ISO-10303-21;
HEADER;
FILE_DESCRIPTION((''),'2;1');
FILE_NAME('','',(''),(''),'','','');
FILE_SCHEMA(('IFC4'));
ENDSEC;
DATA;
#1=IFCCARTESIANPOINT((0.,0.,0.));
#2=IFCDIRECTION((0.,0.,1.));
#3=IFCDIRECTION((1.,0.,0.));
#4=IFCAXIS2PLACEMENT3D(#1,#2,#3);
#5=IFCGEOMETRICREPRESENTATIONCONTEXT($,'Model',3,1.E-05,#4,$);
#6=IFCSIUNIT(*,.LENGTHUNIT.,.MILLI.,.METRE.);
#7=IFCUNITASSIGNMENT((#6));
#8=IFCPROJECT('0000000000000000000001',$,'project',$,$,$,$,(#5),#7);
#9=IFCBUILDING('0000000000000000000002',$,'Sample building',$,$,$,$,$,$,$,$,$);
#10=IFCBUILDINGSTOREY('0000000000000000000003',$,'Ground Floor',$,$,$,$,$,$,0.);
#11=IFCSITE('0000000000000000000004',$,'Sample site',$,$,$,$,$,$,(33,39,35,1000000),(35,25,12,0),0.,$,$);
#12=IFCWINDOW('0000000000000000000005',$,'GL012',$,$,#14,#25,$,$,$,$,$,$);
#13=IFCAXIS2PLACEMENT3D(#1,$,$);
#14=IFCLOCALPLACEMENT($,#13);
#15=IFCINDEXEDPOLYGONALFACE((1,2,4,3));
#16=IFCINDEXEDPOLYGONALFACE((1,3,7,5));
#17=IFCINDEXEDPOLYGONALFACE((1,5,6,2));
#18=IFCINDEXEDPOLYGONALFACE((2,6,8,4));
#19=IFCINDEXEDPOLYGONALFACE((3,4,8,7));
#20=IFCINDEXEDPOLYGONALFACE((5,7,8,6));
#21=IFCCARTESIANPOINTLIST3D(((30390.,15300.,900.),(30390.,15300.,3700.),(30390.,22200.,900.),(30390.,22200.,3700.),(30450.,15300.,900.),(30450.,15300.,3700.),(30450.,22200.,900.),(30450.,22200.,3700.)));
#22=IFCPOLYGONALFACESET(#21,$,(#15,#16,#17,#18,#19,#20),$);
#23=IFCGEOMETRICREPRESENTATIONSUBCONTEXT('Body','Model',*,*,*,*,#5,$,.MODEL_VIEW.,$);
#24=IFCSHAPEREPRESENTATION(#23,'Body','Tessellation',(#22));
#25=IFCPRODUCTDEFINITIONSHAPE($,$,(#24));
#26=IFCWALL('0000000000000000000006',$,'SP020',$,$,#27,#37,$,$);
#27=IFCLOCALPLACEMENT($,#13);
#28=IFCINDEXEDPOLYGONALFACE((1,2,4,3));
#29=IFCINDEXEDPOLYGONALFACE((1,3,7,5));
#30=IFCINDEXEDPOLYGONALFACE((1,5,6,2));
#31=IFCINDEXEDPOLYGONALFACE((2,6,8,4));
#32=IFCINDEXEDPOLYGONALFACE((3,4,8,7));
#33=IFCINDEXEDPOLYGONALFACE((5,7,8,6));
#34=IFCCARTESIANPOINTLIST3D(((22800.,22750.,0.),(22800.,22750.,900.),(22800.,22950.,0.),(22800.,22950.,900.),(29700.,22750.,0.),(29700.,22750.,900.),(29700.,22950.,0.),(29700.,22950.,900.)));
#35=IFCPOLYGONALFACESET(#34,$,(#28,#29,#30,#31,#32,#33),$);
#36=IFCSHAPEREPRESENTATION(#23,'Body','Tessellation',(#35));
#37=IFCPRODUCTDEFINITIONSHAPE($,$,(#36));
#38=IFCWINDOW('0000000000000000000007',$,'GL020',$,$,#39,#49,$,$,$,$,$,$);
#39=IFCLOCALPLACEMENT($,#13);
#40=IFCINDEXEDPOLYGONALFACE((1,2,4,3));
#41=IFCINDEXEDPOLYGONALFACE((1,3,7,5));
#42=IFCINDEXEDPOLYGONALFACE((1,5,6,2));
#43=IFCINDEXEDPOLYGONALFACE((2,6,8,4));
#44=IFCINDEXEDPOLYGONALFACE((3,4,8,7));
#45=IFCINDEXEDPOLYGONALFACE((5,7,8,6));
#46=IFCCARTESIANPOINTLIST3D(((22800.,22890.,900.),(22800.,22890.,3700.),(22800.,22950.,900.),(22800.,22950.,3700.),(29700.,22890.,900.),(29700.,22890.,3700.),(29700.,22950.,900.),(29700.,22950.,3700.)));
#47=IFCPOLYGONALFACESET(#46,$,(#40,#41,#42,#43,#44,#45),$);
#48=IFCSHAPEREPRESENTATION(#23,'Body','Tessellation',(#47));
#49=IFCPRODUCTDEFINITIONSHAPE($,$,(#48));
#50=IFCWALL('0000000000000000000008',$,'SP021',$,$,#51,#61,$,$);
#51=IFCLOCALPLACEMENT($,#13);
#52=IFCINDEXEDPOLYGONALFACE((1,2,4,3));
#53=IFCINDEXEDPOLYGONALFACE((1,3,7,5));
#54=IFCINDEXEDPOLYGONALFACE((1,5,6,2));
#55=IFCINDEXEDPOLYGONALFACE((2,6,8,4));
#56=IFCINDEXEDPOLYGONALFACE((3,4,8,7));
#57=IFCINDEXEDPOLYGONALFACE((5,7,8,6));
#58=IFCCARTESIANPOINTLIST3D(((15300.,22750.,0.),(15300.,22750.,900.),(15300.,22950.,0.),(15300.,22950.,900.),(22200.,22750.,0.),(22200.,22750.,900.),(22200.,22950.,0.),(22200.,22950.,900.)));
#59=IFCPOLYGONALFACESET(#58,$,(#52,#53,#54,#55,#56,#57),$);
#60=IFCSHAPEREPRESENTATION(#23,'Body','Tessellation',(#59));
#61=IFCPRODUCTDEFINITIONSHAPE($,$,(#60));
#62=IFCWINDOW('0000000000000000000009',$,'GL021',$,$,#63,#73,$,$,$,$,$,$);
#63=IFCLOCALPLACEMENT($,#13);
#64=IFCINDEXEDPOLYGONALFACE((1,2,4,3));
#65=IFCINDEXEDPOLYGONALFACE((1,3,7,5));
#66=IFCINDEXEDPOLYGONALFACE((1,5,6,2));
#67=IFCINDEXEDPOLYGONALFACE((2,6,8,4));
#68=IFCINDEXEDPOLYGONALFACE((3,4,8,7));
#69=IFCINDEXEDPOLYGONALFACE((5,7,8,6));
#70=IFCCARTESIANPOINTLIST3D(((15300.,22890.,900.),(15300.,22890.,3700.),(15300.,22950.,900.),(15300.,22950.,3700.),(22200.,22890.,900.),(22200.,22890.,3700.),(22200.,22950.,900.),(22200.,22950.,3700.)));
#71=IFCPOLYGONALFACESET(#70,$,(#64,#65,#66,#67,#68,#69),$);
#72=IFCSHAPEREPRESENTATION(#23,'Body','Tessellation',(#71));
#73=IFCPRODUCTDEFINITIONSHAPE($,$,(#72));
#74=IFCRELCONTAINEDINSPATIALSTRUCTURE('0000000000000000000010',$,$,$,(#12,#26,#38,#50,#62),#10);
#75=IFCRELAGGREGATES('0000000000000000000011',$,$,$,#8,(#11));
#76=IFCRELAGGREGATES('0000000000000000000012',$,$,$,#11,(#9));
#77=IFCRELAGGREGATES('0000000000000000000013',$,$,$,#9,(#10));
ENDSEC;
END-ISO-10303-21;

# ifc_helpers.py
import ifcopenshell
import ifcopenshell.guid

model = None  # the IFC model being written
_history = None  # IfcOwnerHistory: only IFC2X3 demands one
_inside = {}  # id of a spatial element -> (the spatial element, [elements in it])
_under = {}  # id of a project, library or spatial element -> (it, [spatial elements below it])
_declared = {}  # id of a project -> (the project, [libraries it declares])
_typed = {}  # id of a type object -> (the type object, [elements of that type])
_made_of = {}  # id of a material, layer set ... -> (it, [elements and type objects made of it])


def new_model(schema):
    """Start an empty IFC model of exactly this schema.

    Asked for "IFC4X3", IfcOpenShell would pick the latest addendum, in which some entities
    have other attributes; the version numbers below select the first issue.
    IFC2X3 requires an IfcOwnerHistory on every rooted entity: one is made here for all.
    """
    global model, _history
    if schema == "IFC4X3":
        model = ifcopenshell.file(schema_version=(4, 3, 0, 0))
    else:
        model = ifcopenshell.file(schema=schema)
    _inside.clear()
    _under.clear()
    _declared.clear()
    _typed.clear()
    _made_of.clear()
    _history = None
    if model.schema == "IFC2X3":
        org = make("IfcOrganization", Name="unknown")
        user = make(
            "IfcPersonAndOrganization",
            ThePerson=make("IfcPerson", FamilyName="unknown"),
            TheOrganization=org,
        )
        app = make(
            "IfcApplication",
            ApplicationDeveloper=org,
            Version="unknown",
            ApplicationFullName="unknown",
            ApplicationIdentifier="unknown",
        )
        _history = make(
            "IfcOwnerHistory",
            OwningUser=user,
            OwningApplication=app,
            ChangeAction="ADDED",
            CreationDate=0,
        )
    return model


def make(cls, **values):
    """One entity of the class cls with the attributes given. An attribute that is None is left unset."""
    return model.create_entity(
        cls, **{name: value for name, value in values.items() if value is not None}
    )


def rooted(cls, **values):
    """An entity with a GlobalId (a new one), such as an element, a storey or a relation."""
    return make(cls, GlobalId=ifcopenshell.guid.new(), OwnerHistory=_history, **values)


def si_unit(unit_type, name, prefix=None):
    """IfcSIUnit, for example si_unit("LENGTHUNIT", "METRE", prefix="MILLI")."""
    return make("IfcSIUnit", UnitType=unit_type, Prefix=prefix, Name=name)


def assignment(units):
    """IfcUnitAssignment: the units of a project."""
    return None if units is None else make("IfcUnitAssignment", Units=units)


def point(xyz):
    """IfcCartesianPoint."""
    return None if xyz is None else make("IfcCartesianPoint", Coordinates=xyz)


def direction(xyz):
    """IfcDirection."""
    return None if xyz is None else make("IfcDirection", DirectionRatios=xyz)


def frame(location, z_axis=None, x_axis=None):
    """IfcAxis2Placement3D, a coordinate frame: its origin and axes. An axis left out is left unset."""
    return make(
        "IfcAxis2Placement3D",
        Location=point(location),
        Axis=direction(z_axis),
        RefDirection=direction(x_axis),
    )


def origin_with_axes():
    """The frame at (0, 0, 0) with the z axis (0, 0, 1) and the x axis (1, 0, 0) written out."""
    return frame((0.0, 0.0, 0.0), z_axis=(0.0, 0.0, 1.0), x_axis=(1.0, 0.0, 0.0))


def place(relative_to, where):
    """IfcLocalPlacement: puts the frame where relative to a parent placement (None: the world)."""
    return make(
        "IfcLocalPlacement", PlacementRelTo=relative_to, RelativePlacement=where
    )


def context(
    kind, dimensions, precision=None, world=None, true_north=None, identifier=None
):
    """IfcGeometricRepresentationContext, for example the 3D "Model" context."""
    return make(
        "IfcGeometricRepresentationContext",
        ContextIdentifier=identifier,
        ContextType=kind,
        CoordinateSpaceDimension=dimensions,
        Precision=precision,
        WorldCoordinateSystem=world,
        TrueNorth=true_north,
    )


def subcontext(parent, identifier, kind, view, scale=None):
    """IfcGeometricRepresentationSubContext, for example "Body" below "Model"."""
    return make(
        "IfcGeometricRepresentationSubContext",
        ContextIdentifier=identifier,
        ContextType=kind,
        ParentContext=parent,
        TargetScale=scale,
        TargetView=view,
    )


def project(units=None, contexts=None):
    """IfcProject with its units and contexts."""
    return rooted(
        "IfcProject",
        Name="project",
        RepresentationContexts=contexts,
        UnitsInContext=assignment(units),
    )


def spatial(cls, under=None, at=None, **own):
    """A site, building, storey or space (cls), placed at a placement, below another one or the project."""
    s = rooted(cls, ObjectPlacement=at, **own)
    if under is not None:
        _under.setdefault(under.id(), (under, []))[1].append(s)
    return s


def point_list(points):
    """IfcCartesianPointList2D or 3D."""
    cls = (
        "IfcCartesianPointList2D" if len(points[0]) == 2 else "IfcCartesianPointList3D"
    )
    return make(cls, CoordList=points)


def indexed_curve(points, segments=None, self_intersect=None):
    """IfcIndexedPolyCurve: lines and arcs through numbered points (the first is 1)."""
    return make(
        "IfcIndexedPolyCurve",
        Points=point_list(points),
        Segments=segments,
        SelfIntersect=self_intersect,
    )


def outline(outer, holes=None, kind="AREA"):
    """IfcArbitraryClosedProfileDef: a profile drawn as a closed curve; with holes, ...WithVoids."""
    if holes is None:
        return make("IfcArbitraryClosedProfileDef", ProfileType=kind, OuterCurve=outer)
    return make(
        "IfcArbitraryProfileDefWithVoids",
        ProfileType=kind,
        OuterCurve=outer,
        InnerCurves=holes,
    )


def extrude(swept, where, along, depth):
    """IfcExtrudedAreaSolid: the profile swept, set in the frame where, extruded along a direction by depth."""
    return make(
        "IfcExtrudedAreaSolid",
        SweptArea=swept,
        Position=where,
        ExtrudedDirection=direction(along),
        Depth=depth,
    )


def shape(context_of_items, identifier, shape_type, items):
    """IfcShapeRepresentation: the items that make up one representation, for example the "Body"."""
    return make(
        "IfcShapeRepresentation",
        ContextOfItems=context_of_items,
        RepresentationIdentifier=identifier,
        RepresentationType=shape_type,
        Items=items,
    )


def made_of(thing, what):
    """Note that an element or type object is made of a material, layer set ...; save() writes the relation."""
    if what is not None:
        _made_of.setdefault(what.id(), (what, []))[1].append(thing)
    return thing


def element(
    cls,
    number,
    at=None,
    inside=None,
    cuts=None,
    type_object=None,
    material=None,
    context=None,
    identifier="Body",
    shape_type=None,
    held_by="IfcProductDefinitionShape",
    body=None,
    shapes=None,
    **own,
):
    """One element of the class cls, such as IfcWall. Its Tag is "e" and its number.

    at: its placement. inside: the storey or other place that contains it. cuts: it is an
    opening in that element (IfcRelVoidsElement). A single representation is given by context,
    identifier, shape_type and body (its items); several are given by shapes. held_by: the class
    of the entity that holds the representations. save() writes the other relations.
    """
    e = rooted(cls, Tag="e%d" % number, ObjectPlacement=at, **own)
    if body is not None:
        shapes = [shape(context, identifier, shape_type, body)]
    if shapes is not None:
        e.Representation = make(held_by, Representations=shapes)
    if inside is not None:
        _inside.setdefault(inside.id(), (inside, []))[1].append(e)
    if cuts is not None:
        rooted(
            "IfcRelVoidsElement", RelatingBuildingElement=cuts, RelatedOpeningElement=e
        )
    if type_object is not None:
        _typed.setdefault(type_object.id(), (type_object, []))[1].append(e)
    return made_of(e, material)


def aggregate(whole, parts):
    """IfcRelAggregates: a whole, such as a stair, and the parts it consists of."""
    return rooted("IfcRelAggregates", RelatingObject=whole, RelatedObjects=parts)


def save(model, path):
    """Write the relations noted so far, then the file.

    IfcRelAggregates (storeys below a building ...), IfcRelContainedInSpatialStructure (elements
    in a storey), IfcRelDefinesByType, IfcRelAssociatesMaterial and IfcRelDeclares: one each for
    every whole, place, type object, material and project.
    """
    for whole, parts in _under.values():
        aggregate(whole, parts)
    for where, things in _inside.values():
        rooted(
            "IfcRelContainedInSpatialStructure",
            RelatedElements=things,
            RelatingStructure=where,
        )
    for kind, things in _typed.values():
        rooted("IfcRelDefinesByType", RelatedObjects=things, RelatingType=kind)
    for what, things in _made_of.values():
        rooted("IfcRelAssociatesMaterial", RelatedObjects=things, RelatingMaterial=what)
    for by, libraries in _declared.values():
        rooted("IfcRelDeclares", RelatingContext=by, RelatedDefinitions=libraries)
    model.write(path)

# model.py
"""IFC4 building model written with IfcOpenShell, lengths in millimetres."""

from ifc_helpers import new_model, si_unit, frame, origin_with_axes, place, context, subcontext, project, spatial, indexed_curve, outline, extrude, element, save


model = new_model("IFC4")

# Units and contexts
model_context = context("Model", 3, precision=1e-05, world=origin_with_axes())
body_context = subcontext(model_context, "Body", "Model", "MODEL_VIEW")
ifc_project = project(units=[si_unit("LENGTHUNIT", "METRE", prefix="MILLI")], contexts=[model_context])

# Site, building, storey
site = spatial("IfcSite", under=ifc_project, Name="Sample site", RefLatitude=(33, 39, 35, 1000000), RefLongitude=(35, 25, 12, 0), RefElevation=0.0)
building = spatial("IfcBuilding", under=site, Name="Sample building")
storey = spatial("IfcBuildingStorey", under=building, Name="Ground Floor", Elevation=0.0)

# Window
window_1_placement = place(None, frame((30450.0, 15300.0, 900.0), z_axis=(0.0, 0.0, 1.0), x_axis=(0.0, 1.0, 0.0)))
element("IfcWindow", 1, at=window_1_placement, inside=storey, Name="GL012", context=body_context, shape_type="SweptSolid", body=[
    extrude(outline(indexed_curve([(0.0, 0.0), (0.0, 60.0), (6900.0, 60.0), (6900.0, 0.0), (0.0, 0.0)], self_intersect=False)), origin_with_axes(), (0.0, 0.0, 1.0), 2800.0),
])

# Wall
wall_1_placement = place(None, frame((29700.0, 22950.0, 0.0), z_axis=(0.0, 0.0, 1.0), x_axis=(-1.0, 0.0, 0.0)))
element("IfcWall", 2, at=wall_1_placement, inside=storey, Name="SP020", context=body_context, shape_type="SweptSolid", body=[
    extrude(outline(indexed_curve([(0.0, 0.0), (0.0, 200.0), (6900.0, 200.0), (6900.0, 0.0), (0.0, 0.0)], self_intersect=False)), origin_with_axes(), (0.0, 0.0, 1.0), 900.0),
])

# Window
window_2_placement = place(None, frame((29700.0, 22950.0, 900.0), z_axis=(0.0, 0.0, 1.0), x_axis=(-1.0, 0.0, 0.0)))
element("IfcWindow", 3, at=window_2_placement, inside=storey, Name="GL020", context=body_context, shape_type="SweptSolid", body=[
    extrude(outline(indexed_curve([(0.0, 0.0), (0.0, 60.0), (6900.0, 60.0), (6900.0, 0.0), (0.0, 0.0)], self_intersect=False)), origin_with_axes(), (0.0, 0.0, 1.0), 2800.0),
])

# Wall
wall_2_placement = place(None, frame((22200.0, 22950.0, 0.0), z_axis=(0.0, 0.0, 1.0), x_axis=(-1.0, 0.0, 0.0)))
element("IfcWall", 4, at=wall_2_placement, inside=storey, Name="SP021", context=body_context, shape_type="SweptSolid", body=[
    extrude(outline(indexed_curve([(0.0, 0.0), (0.0, 200.0), (6900.0, 200.0), (6900.0, 0.0), (0.0, 0.0)], self_intersect=False)), origin_with_axes(), (0.0, 0.0, 1.0), 900.0),
])

# Window
window_3_placement = place(None, frame((22200.0, 22950.0, 900.0), z_axis=(0.0, 0.0, 1.0), x_axis=(-1.0, 0.0, 0.0)))
element("IfcWindow", 5, at=window_3_placement, inside=storey, Name="GL021", context=body_context, shape_type="SweptSolid", body=[
    extrude(outline(indexed_curve([(0.0, 0.0), (0.0, 60.0), (6900.0, 60.0), (6900.0, 0.0), (0.0, 0.0)], self_intersect=False)), origin_with_axes(), (0.0, 0.0, 1.0), 2800.0),
])

save(model, "model.ifc")
